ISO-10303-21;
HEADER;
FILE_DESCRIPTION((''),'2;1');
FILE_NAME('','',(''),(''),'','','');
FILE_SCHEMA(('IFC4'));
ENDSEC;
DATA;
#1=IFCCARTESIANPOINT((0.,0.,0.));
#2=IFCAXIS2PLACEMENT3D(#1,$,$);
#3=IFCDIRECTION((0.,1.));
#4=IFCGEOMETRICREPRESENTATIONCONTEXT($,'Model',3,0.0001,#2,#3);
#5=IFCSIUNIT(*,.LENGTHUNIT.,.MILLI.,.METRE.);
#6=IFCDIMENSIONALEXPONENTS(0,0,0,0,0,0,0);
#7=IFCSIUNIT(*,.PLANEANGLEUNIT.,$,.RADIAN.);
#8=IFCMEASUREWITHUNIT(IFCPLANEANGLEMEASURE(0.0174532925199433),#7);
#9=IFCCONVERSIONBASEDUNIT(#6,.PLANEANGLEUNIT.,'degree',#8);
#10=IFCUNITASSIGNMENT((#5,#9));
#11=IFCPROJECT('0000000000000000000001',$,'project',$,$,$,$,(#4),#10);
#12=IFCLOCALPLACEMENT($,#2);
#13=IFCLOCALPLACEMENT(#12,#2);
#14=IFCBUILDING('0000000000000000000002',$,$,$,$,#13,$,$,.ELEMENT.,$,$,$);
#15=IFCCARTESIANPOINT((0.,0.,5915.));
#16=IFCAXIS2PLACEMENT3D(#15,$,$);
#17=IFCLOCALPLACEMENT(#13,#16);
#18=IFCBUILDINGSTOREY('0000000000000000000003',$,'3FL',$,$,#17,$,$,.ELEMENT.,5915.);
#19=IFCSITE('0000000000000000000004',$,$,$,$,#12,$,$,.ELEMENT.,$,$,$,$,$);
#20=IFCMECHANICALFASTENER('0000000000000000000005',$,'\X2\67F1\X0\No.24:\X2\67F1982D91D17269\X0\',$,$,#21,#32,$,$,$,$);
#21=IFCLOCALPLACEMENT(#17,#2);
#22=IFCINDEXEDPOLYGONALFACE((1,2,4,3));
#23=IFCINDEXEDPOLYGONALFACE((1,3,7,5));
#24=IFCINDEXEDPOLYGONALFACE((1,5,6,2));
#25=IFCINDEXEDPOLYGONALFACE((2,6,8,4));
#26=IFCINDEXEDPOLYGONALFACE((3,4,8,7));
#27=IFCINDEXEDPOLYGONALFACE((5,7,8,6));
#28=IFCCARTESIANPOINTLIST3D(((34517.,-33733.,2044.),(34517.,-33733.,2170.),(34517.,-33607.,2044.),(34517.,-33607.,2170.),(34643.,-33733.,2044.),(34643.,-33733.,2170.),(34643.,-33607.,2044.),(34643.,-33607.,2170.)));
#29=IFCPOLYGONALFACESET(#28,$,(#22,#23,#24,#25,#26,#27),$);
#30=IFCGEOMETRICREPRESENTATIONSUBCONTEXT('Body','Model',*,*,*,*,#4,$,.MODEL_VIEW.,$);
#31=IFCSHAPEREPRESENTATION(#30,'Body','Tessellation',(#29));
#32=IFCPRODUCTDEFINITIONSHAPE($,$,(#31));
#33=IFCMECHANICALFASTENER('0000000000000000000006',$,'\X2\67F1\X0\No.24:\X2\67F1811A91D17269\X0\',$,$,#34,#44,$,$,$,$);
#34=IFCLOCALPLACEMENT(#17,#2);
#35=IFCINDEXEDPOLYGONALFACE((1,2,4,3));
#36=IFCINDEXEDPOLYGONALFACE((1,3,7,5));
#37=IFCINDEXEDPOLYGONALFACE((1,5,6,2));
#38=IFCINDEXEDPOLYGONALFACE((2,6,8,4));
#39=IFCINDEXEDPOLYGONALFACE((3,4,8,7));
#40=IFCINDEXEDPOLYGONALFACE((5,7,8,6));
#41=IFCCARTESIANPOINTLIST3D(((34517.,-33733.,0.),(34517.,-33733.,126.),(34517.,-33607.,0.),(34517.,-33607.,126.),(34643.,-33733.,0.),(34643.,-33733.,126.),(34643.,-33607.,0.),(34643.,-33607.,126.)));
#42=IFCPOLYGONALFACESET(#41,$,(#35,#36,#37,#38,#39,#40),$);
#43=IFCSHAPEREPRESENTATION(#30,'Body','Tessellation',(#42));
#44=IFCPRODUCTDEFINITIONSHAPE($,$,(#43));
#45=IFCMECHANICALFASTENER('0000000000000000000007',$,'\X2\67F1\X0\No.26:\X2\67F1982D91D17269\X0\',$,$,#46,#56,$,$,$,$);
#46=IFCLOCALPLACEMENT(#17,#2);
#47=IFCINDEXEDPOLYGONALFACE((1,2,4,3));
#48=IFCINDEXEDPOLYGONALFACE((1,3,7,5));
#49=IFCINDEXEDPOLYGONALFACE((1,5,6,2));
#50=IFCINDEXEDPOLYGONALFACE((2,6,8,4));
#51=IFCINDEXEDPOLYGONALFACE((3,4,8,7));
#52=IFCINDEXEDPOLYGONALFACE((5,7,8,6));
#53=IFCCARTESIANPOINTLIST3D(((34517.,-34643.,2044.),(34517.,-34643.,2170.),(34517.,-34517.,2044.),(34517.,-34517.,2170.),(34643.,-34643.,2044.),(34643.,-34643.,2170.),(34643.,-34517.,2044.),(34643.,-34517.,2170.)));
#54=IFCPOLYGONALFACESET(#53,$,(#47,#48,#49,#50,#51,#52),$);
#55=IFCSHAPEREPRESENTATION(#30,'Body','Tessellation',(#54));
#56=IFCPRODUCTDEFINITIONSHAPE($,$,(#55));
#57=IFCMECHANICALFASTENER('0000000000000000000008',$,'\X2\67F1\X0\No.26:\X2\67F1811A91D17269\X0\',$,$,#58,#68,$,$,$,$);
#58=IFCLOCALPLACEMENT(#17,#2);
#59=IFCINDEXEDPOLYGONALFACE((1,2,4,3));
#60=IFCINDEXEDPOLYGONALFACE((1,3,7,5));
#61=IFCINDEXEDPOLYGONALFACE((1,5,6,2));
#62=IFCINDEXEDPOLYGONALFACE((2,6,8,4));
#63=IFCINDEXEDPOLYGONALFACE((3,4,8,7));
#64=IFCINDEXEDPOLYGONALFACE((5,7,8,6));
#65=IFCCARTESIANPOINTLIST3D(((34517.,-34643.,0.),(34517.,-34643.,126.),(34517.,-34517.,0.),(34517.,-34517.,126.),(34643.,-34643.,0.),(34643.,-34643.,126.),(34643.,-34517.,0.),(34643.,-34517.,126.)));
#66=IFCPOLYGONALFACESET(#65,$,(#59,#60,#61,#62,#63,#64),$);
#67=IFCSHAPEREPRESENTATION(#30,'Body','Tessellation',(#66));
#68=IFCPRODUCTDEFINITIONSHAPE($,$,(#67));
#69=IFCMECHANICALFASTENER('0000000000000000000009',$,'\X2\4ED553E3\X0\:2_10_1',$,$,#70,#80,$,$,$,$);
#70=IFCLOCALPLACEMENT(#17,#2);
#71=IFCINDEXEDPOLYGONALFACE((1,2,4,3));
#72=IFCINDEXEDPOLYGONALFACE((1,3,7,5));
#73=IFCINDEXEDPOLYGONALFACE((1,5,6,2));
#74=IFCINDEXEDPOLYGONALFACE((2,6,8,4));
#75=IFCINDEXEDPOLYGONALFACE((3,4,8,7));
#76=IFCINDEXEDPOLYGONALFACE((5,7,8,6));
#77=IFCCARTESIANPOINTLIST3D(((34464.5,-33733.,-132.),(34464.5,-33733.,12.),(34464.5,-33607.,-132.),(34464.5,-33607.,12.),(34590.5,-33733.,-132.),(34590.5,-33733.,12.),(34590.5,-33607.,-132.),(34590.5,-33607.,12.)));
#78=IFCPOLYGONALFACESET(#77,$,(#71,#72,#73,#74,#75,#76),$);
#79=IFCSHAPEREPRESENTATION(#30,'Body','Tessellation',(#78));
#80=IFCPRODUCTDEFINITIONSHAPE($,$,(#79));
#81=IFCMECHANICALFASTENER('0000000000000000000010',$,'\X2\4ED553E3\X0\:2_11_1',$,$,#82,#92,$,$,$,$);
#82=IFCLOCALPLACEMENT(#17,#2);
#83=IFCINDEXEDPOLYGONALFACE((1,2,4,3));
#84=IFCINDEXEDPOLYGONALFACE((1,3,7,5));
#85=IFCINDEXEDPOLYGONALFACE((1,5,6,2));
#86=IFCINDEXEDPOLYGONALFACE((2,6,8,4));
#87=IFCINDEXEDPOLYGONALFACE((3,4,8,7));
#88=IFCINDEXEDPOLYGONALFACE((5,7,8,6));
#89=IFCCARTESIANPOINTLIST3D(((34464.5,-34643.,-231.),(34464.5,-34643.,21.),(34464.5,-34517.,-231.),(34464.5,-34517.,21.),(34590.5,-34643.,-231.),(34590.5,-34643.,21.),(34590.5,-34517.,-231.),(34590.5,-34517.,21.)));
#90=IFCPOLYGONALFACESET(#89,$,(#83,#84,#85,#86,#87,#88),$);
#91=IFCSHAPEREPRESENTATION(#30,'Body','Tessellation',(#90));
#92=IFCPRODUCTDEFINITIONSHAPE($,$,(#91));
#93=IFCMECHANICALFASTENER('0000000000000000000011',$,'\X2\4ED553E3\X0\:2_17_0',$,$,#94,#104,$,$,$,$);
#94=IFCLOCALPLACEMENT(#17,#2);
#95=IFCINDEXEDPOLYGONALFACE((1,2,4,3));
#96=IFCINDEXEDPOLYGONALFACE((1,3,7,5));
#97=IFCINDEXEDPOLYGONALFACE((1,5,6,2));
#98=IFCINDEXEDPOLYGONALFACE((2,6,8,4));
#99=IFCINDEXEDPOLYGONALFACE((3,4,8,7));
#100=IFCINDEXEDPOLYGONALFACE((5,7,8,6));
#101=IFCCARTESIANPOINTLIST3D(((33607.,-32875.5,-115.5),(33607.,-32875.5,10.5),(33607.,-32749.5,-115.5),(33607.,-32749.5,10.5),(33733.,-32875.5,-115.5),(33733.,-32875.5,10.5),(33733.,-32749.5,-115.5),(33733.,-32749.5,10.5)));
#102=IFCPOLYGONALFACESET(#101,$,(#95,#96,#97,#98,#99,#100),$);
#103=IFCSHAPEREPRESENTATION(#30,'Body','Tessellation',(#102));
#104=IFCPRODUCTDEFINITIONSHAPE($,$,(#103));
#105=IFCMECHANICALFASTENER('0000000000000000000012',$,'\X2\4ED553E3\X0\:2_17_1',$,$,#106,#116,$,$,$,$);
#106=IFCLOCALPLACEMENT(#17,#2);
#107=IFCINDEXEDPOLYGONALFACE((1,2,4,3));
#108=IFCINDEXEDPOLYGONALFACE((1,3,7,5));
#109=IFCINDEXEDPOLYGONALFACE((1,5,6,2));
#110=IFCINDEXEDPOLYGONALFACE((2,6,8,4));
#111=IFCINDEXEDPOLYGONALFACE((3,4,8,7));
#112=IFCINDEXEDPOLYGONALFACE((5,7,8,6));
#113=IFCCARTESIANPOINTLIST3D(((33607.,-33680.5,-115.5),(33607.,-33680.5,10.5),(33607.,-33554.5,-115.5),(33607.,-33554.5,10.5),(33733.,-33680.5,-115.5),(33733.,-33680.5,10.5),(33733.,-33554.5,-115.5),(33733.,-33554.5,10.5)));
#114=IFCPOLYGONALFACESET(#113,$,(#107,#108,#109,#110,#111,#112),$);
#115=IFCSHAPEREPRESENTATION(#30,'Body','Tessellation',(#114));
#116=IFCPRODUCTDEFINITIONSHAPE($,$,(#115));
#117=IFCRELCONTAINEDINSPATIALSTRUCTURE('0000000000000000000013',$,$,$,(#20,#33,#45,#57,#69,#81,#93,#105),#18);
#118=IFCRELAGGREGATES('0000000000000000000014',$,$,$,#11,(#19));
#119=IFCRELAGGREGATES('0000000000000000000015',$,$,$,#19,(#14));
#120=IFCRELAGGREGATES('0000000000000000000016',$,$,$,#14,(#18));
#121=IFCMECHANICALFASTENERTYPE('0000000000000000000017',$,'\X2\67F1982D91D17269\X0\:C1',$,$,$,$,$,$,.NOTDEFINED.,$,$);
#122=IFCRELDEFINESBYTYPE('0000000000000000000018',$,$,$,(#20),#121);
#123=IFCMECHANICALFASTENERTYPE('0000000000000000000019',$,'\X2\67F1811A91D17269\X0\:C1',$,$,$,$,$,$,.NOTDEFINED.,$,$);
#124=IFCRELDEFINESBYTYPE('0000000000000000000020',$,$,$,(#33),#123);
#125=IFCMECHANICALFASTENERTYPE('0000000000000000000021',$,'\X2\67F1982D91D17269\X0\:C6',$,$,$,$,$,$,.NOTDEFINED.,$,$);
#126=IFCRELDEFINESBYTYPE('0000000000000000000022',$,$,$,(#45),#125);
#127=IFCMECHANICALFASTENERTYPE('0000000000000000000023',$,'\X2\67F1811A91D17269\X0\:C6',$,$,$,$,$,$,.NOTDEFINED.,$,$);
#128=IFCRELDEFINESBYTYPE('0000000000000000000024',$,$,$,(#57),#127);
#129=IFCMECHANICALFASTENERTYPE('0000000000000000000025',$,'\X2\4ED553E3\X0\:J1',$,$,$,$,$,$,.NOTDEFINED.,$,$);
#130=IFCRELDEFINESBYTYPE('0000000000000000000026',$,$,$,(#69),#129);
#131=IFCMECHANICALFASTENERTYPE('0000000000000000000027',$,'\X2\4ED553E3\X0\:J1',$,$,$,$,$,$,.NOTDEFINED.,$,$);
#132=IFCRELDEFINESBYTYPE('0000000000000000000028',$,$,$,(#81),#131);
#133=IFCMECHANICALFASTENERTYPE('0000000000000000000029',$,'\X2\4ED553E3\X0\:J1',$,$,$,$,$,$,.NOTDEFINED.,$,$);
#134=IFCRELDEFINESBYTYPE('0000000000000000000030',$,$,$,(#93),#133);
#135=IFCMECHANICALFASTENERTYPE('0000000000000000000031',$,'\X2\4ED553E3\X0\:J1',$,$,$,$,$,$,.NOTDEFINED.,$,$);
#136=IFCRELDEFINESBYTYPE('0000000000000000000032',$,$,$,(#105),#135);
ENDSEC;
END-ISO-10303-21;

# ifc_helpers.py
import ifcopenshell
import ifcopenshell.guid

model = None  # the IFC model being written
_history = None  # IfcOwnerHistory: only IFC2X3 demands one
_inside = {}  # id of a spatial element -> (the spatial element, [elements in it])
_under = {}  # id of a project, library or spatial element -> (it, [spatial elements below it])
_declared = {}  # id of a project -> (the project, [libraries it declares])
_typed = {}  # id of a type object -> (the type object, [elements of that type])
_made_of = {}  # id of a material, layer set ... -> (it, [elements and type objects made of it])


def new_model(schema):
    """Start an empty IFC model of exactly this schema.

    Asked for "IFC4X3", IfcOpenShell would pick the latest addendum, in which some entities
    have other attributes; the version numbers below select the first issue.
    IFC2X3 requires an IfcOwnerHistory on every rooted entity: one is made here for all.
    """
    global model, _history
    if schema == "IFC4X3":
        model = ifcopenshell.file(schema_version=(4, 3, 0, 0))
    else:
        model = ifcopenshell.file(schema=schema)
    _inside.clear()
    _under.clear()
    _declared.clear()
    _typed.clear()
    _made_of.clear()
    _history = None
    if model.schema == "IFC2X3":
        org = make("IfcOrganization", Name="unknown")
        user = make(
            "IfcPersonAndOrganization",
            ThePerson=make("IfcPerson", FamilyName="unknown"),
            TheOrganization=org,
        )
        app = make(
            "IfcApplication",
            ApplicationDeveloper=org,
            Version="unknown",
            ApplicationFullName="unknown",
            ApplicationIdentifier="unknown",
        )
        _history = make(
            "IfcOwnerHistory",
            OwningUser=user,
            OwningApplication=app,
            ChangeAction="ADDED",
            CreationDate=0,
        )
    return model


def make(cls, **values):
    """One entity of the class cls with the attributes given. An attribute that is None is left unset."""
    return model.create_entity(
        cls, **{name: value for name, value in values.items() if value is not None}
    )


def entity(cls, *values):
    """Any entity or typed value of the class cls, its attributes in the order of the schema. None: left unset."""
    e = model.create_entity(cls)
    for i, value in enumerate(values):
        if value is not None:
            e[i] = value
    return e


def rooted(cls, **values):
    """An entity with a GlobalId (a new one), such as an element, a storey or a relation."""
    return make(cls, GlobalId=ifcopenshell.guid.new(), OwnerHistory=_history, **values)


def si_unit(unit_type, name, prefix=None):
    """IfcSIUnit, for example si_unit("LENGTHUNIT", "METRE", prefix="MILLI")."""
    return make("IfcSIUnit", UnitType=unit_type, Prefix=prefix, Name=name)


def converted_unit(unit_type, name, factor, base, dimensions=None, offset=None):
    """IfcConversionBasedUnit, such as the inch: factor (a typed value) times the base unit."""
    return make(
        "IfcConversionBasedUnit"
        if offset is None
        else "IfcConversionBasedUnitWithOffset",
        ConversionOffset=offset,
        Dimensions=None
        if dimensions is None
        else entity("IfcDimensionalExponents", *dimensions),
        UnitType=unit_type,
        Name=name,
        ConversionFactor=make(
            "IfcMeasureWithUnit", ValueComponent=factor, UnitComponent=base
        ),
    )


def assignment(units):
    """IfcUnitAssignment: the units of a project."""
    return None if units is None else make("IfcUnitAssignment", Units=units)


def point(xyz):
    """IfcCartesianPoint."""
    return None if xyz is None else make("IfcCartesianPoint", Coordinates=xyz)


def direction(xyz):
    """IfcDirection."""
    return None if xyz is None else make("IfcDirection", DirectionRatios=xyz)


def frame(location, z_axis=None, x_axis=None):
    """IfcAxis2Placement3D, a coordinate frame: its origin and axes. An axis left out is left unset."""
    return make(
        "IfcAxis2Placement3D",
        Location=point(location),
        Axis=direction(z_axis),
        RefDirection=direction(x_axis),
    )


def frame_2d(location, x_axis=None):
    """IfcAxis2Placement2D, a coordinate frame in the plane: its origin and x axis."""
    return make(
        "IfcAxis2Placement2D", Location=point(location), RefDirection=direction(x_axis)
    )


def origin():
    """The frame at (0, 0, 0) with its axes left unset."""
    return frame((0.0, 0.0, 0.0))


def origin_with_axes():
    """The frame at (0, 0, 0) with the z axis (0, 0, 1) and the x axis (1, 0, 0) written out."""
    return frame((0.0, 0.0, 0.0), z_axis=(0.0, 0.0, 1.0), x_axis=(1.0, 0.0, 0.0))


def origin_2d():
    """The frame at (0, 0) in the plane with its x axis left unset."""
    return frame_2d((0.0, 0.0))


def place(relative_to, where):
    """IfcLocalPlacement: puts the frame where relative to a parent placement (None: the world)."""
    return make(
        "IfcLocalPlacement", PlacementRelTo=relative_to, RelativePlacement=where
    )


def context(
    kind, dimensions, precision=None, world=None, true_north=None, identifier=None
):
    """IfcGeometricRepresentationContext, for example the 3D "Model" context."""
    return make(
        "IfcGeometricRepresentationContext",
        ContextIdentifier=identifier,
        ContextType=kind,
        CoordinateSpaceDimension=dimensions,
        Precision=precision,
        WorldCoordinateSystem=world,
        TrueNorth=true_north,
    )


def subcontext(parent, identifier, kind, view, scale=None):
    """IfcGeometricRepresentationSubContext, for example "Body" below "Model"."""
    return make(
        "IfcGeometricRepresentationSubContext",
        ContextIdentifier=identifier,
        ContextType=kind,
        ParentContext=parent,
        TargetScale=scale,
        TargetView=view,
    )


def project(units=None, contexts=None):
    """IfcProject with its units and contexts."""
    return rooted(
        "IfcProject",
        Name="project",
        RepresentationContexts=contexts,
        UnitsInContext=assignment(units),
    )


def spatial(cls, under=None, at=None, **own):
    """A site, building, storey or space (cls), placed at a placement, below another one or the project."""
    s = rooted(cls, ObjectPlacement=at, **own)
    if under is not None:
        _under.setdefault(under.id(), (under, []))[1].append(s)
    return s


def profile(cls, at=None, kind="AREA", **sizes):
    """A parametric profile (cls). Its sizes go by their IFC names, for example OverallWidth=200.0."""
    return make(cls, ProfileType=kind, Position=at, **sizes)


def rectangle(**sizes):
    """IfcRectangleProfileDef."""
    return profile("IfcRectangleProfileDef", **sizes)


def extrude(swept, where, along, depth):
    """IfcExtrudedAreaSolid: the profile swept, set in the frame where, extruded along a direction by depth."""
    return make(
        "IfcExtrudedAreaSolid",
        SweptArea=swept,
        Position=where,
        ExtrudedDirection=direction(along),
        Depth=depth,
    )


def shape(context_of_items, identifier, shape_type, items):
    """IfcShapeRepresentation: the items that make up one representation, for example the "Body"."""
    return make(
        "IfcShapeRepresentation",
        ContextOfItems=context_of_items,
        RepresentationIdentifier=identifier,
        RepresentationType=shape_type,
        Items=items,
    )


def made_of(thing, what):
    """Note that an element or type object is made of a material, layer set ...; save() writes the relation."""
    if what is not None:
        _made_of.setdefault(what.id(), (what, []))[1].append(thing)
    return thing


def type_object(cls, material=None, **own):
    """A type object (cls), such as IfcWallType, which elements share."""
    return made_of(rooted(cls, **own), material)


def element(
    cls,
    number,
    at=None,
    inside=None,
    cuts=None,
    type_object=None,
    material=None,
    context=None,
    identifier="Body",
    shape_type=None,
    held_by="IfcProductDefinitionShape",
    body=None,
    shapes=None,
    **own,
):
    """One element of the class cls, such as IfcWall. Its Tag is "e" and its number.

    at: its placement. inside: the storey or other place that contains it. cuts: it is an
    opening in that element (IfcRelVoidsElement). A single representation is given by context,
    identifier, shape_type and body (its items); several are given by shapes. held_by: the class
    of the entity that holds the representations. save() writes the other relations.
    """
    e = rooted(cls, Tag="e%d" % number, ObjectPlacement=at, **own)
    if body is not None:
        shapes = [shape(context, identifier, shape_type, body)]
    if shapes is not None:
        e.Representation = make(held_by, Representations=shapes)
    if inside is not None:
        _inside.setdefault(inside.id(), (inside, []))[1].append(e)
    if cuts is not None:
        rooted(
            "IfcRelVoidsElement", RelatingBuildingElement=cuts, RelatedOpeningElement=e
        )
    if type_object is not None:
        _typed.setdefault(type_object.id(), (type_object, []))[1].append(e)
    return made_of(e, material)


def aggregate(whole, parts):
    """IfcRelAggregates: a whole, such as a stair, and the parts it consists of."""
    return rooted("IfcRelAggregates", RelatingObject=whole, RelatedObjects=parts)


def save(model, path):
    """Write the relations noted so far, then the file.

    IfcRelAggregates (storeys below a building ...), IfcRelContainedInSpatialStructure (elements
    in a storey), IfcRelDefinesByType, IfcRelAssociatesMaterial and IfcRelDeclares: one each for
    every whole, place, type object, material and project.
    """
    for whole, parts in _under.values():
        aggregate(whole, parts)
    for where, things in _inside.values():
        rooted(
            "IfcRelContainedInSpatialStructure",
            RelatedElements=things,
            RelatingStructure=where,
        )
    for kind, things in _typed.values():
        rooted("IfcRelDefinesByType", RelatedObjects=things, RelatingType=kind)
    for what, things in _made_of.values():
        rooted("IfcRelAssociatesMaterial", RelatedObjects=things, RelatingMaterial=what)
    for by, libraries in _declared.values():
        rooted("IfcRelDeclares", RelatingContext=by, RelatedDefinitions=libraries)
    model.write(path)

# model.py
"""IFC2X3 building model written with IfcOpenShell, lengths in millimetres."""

from ifc_helpers import new_model, entity, si_unit, converted_unit, direction, frame, origin, origin_with_axes, origin_2d, place, context, subcontext, project, spatial, rectangle, extrude, type_object, element, save


model = new_model("IFC2X3")

# Units and contexts
model_context = context("Model", 3, precision=0.0001, world=origin(), true_north=direction((0.0, 1.0)))
body_context = subcontext(model_context, "Body", "Model", "MODEL_VIEW")
ifc_project = project(units=[si_unit("LENGTHUNIT", "METRE", prefix="MILLI"), converted_unit("PLANEANGLEUNIT", "degree", entity("IfcPlaneAngleMeasure", 0.0174532925199433), si_unit("PLANEANGLEUNIT", "RADIAN"), dimensions=[0, 0, 0, 0, 0, 0, 0])], contexts=[model_context])

# Site, building, storey
site_placement = place(None, origin())
site = spatial("IfcSite", under=ifc_project, at=site_placement, CompositionType="ELEMENT")
building_placement = place(site_placement, origin())
building = spatial("IfcBuilding", under=site, at=building_placement, CompositionType="ELEMENT")
storey_placement = place(building_placement, frame((0.0, 0.0, 5915.0)))
storey = spatial("IfcBuildingStorey", under=building, at=storey_placement, Name="3FL", CompositionType="ELEMENT", Elevation=5915.0)

# Mechanical fasteners
mechanical_fastener_type_1 = type_object("IfcMechanicalFastenerType", Name="柱頭金物:C1")
mechanical_fastener_1_placement = place(storey_placement, frame((34580.0, -33670.0, 2044.0)))
element("IfcMechanicalFastener", 1, at=mechanical_fastener_1_placement, inside=storey, type_object=mechanical_fastener_type_1, Name="柱No.24:柱頭金物", context=body_context, shape_type="SweptSolid", body=[
    extrude(rectangle(XDim=126.0, YDim=126.0, at=origin_2d()), origin_with_axes(), (0.0, 0.0, 1.0), 126.0),
])
mechanical_fastener_type_2 = type_object("IfcMechanicalFastenerType", Name="柱脚金物:C1")
mechanical_fastener_2_placement = place(storey_placement, frame((34580.0, -33670.0, 0.0)))
element("IfcMechanicalFastener", 2, at=mechanical_fastener_2_placement, inside=storey, type_object=mechanical_fastener_type_2, Name="柱No.24:柱脚金物", context=body_context, shape_type="SweptSolid", body=[
    extrude(rectangle(XDim=126.0, YDim=126.0, at=origin_2d()), origin_with_axes(), (0.0, 0.0, 1.0), 126.0),
])
mechanical_fastener_type_3 = type_object("IfcMechanicalFastenerType", Name="柱頭金物:C6")
mechanical_fastener_3_placement = place(storey_placement, frame((34580.0, -34580.0, 2044.0)))
element("IfcMechanicalFastener", 3, at=mechanical_fastener_3_placement, inside=storey, type_object=mechanical_fastener_type_3, Name="柱No.26:柱頭金物", context=body_context, shape_type="SweptSolid", body=[
    extrude(rectangle(XDim=126.0, YDim=126.0, at=origin_2d()), origin_with_axes(), (0.0, 0.0, 1.0), 126.0),
])
mechanical_fastener_type_4 = type_object("IfcMechanicalFastenerType", Name="柱脚金物:C6")
mechanical_fastener_4_placement = place(storey_placement, frame((34580.0, -34580.0, 0.0)))
element("IfcMechanicalFastener", 4, at=mechanical_fastener_4_placement, inside=storey, type_object=mechanical_fastener_type_4, Name="柱No.26:柱脚金物", context=body_context, shape_type="SweptSolid", body=[
    extrude(rectangle(XDim=126.0, YDim=126.0, at=origin_2d()), origin_with_axes(), (0.0, 0.0, 1.0), 126.0),
])
mechanical_fastener_type_5 = type_object("IfcMechanicalFastenerType", Name="仕口:J1")
mechanical_fastener_5_placement = place(storey_placement, frame((34527.5, -33670.0, -132.0)))
element("IfcMechanicalFastener", 5, at=mechanical_fastener_5_placement, inside=storey, type_object=mechanical_fastener_type_5, Name="仕口:2_10_1", context=body_context, shape_type="SweptSolid", body=[
    extrude(rectangle(XDim=126.0, YDim=126.0, at=origin_2d()), origin_with_axes(), (0.0, 0.0, 1.0), 144.0),
])
mechanical_fastener_type_6 = type_object("IfcMechanicalFastenerType", Name="仕口:J1")
mechanical_fastener_6_placement = place(storey_placement, frame((34527.5, -34580.0, -231.0)))
element("IfcMechanicalFastener", 6, at=mechanical_fastener_6_placement, inside=storey, type_object=mechanical_fastener_type_6, Name="仕口:2_11_1", context=body_context, shape_type="SweptSolid", body=[
    extrude(rectangle(XDim=126.0, YDim=126.0, at=origin_2d()), origin_with_axes(), (0.0, 0.0, 1.0), 252.0),
])
mechanical_fastener_type_7 = type_object("IfcMechanicalFastenerType", Name="仕口:J1")
mechanical_fastener_7_placement = place(storey_placement, frame((33670.0, -32812.5, -115.5)))
element("IfcMechanicalFastener", 7, at=mechanical_fastener_7_placement, inside=storey, type_object=mechanical_fastener_type_7, Name="仕口:2_17_0", context=body_context, shape_type="SweptSolid", body=[
    extrude(rectangle(XDim=126.0, YDim=126.0, at=origin_2d()), origin_with_axes(), (0.0, 0.0, 1.0), 126.0),
])
mechanical_fastener_type_8 = type_object("IfcMechanicalFastenerType", Name="仕口:J1")
mechanical_fastener_8_placement = place(storey_placement, frame((33670.0, -33617.5, -115.5)))
element("IfcMechanicalFastener", 8, at=mechanical_fastener_8_placement, inside=storey, type_object=mechanical_fastener_type_8, Name="仕口:2_17_1", context=body_context, shape_type="SweptSolid", body=[
    extrude(rectangle(XDim=126.0, YDim=126.0, at=origin_2d()), origin_with_axes(), (0.0, 0.0, 1.0), 126.0),
])

save(model, "model.ifc")
